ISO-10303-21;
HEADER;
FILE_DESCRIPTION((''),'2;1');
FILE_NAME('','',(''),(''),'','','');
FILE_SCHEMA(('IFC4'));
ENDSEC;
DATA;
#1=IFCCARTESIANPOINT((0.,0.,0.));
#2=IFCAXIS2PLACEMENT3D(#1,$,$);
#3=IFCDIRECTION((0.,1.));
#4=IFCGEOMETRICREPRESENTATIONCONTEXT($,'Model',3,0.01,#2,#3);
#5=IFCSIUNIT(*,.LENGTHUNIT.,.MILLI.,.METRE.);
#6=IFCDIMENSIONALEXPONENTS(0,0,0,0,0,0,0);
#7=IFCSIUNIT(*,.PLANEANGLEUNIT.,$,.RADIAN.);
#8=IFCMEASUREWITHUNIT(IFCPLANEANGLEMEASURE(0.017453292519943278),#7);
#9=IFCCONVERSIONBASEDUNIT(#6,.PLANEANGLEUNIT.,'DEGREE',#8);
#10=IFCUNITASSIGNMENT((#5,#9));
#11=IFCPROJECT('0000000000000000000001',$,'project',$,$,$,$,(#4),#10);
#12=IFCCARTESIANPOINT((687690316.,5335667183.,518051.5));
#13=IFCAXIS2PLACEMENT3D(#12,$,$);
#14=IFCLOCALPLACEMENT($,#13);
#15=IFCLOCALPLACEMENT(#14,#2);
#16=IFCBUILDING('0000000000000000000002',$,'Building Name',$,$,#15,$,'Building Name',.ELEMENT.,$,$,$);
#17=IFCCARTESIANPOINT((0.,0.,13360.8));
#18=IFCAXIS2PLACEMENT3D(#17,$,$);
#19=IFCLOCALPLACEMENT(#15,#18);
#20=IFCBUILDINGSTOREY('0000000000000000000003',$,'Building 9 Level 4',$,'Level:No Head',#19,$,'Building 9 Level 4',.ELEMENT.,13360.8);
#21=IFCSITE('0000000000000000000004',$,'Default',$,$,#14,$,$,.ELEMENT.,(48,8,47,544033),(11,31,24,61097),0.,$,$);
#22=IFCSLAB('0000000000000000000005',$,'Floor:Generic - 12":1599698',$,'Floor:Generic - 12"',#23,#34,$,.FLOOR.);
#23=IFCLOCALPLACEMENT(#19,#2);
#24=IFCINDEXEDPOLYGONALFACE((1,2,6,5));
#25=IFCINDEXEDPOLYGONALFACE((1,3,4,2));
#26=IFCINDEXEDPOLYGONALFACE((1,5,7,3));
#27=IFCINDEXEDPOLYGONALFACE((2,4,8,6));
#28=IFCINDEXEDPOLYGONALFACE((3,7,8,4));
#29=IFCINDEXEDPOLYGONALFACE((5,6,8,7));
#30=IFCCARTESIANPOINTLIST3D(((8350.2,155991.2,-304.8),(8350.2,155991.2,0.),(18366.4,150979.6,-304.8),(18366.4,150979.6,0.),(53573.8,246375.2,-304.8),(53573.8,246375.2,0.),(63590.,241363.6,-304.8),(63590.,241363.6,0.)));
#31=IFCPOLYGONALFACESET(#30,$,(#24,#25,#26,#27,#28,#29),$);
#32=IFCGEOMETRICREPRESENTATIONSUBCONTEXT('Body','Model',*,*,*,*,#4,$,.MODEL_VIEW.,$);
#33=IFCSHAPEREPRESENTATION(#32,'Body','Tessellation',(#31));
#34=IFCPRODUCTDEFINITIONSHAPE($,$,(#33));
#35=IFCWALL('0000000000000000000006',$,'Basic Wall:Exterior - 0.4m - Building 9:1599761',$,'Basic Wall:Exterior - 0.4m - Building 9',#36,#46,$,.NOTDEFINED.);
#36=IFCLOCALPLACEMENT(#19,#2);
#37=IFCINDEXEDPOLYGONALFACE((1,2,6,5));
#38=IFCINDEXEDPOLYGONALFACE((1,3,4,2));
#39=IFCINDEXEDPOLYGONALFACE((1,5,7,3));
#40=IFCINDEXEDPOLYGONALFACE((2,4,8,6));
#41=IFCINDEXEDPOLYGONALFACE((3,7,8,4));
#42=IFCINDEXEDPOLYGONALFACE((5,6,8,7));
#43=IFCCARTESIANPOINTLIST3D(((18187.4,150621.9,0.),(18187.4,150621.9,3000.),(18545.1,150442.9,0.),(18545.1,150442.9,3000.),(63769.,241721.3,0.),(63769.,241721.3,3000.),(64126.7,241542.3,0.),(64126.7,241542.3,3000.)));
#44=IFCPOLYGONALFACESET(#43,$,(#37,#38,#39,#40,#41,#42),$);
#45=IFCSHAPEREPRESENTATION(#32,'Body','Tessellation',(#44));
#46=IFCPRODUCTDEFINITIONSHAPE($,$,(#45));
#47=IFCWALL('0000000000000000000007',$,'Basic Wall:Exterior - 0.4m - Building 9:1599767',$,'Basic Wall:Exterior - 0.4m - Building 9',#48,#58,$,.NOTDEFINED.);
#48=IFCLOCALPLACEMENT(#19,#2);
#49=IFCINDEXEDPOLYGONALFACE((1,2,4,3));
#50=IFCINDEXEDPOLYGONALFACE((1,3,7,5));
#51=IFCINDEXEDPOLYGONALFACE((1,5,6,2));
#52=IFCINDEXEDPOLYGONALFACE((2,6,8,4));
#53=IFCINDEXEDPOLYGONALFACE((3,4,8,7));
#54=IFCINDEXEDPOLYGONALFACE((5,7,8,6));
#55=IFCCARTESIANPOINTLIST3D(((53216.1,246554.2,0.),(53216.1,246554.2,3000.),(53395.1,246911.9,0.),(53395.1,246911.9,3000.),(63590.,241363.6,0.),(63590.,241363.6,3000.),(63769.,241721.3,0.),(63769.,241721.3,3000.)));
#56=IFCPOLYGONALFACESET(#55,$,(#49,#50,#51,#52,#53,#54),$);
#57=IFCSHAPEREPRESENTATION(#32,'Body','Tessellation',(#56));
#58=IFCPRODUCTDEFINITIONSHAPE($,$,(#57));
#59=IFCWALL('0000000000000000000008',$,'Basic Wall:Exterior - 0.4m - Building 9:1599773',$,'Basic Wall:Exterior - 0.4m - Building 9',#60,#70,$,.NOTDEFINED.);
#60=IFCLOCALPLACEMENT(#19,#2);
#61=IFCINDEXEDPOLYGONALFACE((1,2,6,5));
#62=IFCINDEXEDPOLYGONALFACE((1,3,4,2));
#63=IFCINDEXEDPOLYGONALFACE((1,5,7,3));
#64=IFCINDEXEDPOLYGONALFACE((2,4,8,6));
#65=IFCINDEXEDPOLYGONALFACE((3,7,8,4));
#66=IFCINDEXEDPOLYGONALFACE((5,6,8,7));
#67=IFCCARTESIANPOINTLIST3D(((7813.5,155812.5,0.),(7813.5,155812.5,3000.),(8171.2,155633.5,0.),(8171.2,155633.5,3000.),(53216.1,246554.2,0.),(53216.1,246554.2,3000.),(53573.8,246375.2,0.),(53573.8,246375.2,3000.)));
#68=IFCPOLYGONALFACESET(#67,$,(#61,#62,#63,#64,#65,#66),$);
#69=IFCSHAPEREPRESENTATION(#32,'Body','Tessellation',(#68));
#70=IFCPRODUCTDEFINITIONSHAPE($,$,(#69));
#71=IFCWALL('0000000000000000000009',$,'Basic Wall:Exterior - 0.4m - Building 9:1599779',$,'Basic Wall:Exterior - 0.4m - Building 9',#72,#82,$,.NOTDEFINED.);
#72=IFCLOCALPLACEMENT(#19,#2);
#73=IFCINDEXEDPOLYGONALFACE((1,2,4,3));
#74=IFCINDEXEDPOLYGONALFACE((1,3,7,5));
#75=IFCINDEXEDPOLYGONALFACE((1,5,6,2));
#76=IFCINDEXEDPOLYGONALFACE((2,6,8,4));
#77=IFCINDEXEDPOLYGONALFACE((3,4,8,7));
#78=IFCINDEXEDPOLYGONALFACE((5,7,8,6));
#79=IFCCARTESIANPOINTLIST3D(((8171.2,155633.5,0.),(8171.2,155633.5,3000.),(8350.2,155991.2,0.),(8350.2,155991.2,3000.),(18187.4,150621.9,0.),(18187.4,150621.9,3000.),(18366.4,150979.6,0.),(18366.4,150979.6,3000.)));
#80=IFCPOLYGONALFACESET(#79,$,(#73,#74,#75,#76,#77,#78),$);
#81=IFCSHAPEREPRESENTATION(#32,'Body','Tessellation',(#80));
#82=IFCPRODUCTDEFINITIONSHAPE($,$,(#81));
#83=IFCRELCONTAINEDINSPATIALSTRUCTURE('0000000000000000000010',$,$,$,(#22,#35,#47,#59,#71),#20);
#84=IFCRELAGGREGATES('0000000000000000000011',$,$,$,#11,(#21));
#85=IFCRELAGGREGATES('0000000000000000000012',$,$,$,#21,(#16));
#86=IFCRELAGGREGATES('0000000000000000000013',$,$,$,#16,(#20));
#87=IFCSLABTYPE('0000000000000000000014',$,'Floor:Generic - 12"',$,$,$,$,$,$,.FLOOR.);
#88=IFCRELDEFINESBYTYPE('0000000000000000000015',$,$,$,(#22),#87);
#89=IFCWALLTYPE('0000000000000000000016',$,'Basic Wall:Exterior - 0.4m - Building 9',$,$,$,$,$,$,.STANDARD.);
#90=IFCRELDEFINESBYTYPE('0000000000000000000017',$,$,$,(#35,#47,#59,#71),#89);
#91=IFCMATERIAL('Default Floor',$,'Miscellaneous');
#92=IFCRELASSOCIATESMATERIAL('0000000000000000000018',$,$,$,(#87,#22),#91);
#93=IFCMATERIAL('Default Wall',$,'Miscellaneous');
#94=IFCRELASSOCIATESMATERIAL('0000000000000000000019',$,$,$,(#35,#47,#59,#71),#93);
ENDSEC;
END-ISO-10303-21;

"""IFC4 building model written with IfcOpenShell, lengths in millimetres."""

from ifc_helpers import new_model, entity, si_unit, converted_unit, direction, frame, origin, place, context, subcontext, project, spatial, indexed_curve, outline, extrude, material, type_object, element, save


model = new_model("IFC4")

# Units and contexts
model_context = context("Model", 3, precision=0.01, world=origin(), true_north=direction((0.0, 1.0)))
body_context = subcontext(model_context, "Body", "Model", "MODEL_VIEW")
ifc_project = project(units=[si_unit("LENGTHUNIT", "METRE", prefix="MILLI"), converted_unit("PLANEANGLEUNIT", "DEGREE", entity("IfcPlaneAngleMeasure", 0.017453292519943278), si_unit("PLANEANGLEUNIT", "RADIAN"), dimensions=[0, 0, 0, 0, 0, 0, 0])], contexts=[model_context])

# Site, building, storey
site_placement = place(None, frame((687690316.0, 5335667183.0, 518051.5)))
site = spatial("IfcSite", under=ifc_project, at=site_placement, Name="Default", CompositionType="ELEMENT", RefLatitude=(48, 8, 47, 544033), RefLongitude=(11, 31, 24, 61097), RefElevation=0.0)
building_placement = place(site_placement, origin())
building = spatial("IfcBuilding", under=site, at=building_placement, Name="Building Name", LongName="Building Name", CompositionType="ELEMENT")
storey_placement = place(building_placement, frame((0.0, 0.0, 13360.8)))
storey = spatial("IfcBuildingStorey", under=building, at=storey_placement, Name="Building 9 Level 4", ObjectType="Level:No Head", LongName="Building 9 Level 4", CompositionType="ELEMENT", Elevation=13360.8)

# Slab
ifc_material_1 = material(Name="Default Floor", Category="Miscellaneous")
slab_type = type_object("IfcSlabType", Name="Floor:Generic - 12\"", PredefinedType="FLOOR", material=ifc_material_1)
slab_placement = place(storey_placement, origin())
element("IfcSlab", 1, at=slab_placement, inside=storey, type_object=slab_type, material=ifc_material_1, Name="Floor:Generic - 12\":1599698", ObjectType="Floor:Generic - 12\"", PredefinedType="FLOOR", context=body_context, shape_type="SweptSolid", body=[
    extrude(outline(indexed_curve([(-50533.2, -5600.0), (50533.2, -5600.0), (50533.2, 5600.0), (-50533.2, 5600.0), (-50533.2, -5600.0)], self_intersect=False)), frame((35970.1, 198677.4, 0.0), z_axis=(0.0, 0.0, -1.0), x_axis=(-0.447464, -0.894302, 0.0)), (0.0, 0.0, 1.0), 304.8),
])

# Walls
ifc_material_2 = material(Name="Default Wall", Category="Miscellaneous")
wall_type = type_object("IfcWallType", Name="Basic Wall:Exterior - 0.4m - Building 9", PredefinedType="STANDARD")
wall_1_placement = place(storey_placement, frame((18366.3, 150532.4, 0.0), z_axis=(0.0, 0.0, 1.0), x_axis=(0.447464, 0.894302, 0.0)))
element("IfcWall", 2, at=wall_1_placement, inside=storey, type_object=wall_type, material=ifc_material_2, Name="Basic Wall:Exterior - 0.4m - Building 9:1599761", ObjectType="Basic Wall:Exterior - 0.4m - Building 9", PredefinedType="NOTDEFINED", context=body_context, shape_type="SweptSolid", body=[
    extrude(outline(indexed_curve([(101866.5, 200.0), (0.0, 200.0), (0.0, -200.0), (101866.5, -200.0), (101866.5, 200.0)], self_intersect=False)), origin(), (0.0, 0.0, 1.0), 3000.0),
])
wall_2_placement = place(storey_placement, frame((63679.5, 241542.5, 0.0), z_axis=(0.0, 0.0, 1.0), x_axis=(-0.894302, 0.447464, 0.0)))
element("IfcWall", 3, at=wall_2_placement, inside=storey, type_object=wall_type, material=ifc_material_2, Name="Basic Wall:Exterior - 0.4m - Building 9:1599767", ObjectType="Basic Wall:Exterior - 0.4m - Building 9", PredefinedType="NOTDEFINED", context=body_context, shape_type="SweptSolid", body=[
    extrude(outline(indexed_curve([(11600.0, 200.0), (0.0, 200.0), (0.0, -200.0), (11600.0, -200.0), (11600.0, 200.0)], self_intersect=False)), origin(), (0.0, 0.0, 1.0), 3000.0),
])
wall_3_placement = place(storey_placement, frame((53395.0, 246464.7, 0.0), z_axis=(0.0, 0.0, 1.0), x_axis=(-0.447464, -0.894302, 0.0)))
element("IfcWall", 4, at=wall_3_placement, inside=storey, type_object=wall_type, material=ifc_material_2, Name="Basic Wall:Exterior - 0.4m - Building 9:1599773", ObjectType="Basic Wall:Exterior - 0.4m - Building 9", PredefinedType="NOTDEFINED", context=body_context, shape_type="SweptSolid", body=[
    extrude(outline(indexed_curve([(101466.5, 200.0), (0.0, 200.0), (0.0, -200.0), (101466.5, -200.0), (101466.5, 200.0)], self_intersect=False)), origin(), (0.0, 0.0, 1.0), 3000.0),
])
wall_4_placement = place(storey_placement, frame((8260.7, 155812.4, 0.0), z_axis=(0.0, 0.0, 1.0), x_axis=(0.894302, -0.447464, 0.0)))
element("IfcWall", 5, at=wall_4_placement, inside=storey, type_object=wall_type, material=ifc_material_2, Name="Basic Wall:Exterior - 0.4m - Building 9:1599779", ObjectType="Basic Wall:Exterior - 0.4m - Building 9", PredefinedType="NOTDEFINED", context=body_context, shape_type="SweptSolid", body=[
    extrude(outline(indexed_curve([(11200.0, 200.0), (0.0, 200.0), (0.0, -200.0), (11200.0, -200.0), (11200.0, 200.0)], self_intersect=False)), origin(), (0.0, 0.0, 1.0), 3000.0),
])

save(model, "model.ifc")
